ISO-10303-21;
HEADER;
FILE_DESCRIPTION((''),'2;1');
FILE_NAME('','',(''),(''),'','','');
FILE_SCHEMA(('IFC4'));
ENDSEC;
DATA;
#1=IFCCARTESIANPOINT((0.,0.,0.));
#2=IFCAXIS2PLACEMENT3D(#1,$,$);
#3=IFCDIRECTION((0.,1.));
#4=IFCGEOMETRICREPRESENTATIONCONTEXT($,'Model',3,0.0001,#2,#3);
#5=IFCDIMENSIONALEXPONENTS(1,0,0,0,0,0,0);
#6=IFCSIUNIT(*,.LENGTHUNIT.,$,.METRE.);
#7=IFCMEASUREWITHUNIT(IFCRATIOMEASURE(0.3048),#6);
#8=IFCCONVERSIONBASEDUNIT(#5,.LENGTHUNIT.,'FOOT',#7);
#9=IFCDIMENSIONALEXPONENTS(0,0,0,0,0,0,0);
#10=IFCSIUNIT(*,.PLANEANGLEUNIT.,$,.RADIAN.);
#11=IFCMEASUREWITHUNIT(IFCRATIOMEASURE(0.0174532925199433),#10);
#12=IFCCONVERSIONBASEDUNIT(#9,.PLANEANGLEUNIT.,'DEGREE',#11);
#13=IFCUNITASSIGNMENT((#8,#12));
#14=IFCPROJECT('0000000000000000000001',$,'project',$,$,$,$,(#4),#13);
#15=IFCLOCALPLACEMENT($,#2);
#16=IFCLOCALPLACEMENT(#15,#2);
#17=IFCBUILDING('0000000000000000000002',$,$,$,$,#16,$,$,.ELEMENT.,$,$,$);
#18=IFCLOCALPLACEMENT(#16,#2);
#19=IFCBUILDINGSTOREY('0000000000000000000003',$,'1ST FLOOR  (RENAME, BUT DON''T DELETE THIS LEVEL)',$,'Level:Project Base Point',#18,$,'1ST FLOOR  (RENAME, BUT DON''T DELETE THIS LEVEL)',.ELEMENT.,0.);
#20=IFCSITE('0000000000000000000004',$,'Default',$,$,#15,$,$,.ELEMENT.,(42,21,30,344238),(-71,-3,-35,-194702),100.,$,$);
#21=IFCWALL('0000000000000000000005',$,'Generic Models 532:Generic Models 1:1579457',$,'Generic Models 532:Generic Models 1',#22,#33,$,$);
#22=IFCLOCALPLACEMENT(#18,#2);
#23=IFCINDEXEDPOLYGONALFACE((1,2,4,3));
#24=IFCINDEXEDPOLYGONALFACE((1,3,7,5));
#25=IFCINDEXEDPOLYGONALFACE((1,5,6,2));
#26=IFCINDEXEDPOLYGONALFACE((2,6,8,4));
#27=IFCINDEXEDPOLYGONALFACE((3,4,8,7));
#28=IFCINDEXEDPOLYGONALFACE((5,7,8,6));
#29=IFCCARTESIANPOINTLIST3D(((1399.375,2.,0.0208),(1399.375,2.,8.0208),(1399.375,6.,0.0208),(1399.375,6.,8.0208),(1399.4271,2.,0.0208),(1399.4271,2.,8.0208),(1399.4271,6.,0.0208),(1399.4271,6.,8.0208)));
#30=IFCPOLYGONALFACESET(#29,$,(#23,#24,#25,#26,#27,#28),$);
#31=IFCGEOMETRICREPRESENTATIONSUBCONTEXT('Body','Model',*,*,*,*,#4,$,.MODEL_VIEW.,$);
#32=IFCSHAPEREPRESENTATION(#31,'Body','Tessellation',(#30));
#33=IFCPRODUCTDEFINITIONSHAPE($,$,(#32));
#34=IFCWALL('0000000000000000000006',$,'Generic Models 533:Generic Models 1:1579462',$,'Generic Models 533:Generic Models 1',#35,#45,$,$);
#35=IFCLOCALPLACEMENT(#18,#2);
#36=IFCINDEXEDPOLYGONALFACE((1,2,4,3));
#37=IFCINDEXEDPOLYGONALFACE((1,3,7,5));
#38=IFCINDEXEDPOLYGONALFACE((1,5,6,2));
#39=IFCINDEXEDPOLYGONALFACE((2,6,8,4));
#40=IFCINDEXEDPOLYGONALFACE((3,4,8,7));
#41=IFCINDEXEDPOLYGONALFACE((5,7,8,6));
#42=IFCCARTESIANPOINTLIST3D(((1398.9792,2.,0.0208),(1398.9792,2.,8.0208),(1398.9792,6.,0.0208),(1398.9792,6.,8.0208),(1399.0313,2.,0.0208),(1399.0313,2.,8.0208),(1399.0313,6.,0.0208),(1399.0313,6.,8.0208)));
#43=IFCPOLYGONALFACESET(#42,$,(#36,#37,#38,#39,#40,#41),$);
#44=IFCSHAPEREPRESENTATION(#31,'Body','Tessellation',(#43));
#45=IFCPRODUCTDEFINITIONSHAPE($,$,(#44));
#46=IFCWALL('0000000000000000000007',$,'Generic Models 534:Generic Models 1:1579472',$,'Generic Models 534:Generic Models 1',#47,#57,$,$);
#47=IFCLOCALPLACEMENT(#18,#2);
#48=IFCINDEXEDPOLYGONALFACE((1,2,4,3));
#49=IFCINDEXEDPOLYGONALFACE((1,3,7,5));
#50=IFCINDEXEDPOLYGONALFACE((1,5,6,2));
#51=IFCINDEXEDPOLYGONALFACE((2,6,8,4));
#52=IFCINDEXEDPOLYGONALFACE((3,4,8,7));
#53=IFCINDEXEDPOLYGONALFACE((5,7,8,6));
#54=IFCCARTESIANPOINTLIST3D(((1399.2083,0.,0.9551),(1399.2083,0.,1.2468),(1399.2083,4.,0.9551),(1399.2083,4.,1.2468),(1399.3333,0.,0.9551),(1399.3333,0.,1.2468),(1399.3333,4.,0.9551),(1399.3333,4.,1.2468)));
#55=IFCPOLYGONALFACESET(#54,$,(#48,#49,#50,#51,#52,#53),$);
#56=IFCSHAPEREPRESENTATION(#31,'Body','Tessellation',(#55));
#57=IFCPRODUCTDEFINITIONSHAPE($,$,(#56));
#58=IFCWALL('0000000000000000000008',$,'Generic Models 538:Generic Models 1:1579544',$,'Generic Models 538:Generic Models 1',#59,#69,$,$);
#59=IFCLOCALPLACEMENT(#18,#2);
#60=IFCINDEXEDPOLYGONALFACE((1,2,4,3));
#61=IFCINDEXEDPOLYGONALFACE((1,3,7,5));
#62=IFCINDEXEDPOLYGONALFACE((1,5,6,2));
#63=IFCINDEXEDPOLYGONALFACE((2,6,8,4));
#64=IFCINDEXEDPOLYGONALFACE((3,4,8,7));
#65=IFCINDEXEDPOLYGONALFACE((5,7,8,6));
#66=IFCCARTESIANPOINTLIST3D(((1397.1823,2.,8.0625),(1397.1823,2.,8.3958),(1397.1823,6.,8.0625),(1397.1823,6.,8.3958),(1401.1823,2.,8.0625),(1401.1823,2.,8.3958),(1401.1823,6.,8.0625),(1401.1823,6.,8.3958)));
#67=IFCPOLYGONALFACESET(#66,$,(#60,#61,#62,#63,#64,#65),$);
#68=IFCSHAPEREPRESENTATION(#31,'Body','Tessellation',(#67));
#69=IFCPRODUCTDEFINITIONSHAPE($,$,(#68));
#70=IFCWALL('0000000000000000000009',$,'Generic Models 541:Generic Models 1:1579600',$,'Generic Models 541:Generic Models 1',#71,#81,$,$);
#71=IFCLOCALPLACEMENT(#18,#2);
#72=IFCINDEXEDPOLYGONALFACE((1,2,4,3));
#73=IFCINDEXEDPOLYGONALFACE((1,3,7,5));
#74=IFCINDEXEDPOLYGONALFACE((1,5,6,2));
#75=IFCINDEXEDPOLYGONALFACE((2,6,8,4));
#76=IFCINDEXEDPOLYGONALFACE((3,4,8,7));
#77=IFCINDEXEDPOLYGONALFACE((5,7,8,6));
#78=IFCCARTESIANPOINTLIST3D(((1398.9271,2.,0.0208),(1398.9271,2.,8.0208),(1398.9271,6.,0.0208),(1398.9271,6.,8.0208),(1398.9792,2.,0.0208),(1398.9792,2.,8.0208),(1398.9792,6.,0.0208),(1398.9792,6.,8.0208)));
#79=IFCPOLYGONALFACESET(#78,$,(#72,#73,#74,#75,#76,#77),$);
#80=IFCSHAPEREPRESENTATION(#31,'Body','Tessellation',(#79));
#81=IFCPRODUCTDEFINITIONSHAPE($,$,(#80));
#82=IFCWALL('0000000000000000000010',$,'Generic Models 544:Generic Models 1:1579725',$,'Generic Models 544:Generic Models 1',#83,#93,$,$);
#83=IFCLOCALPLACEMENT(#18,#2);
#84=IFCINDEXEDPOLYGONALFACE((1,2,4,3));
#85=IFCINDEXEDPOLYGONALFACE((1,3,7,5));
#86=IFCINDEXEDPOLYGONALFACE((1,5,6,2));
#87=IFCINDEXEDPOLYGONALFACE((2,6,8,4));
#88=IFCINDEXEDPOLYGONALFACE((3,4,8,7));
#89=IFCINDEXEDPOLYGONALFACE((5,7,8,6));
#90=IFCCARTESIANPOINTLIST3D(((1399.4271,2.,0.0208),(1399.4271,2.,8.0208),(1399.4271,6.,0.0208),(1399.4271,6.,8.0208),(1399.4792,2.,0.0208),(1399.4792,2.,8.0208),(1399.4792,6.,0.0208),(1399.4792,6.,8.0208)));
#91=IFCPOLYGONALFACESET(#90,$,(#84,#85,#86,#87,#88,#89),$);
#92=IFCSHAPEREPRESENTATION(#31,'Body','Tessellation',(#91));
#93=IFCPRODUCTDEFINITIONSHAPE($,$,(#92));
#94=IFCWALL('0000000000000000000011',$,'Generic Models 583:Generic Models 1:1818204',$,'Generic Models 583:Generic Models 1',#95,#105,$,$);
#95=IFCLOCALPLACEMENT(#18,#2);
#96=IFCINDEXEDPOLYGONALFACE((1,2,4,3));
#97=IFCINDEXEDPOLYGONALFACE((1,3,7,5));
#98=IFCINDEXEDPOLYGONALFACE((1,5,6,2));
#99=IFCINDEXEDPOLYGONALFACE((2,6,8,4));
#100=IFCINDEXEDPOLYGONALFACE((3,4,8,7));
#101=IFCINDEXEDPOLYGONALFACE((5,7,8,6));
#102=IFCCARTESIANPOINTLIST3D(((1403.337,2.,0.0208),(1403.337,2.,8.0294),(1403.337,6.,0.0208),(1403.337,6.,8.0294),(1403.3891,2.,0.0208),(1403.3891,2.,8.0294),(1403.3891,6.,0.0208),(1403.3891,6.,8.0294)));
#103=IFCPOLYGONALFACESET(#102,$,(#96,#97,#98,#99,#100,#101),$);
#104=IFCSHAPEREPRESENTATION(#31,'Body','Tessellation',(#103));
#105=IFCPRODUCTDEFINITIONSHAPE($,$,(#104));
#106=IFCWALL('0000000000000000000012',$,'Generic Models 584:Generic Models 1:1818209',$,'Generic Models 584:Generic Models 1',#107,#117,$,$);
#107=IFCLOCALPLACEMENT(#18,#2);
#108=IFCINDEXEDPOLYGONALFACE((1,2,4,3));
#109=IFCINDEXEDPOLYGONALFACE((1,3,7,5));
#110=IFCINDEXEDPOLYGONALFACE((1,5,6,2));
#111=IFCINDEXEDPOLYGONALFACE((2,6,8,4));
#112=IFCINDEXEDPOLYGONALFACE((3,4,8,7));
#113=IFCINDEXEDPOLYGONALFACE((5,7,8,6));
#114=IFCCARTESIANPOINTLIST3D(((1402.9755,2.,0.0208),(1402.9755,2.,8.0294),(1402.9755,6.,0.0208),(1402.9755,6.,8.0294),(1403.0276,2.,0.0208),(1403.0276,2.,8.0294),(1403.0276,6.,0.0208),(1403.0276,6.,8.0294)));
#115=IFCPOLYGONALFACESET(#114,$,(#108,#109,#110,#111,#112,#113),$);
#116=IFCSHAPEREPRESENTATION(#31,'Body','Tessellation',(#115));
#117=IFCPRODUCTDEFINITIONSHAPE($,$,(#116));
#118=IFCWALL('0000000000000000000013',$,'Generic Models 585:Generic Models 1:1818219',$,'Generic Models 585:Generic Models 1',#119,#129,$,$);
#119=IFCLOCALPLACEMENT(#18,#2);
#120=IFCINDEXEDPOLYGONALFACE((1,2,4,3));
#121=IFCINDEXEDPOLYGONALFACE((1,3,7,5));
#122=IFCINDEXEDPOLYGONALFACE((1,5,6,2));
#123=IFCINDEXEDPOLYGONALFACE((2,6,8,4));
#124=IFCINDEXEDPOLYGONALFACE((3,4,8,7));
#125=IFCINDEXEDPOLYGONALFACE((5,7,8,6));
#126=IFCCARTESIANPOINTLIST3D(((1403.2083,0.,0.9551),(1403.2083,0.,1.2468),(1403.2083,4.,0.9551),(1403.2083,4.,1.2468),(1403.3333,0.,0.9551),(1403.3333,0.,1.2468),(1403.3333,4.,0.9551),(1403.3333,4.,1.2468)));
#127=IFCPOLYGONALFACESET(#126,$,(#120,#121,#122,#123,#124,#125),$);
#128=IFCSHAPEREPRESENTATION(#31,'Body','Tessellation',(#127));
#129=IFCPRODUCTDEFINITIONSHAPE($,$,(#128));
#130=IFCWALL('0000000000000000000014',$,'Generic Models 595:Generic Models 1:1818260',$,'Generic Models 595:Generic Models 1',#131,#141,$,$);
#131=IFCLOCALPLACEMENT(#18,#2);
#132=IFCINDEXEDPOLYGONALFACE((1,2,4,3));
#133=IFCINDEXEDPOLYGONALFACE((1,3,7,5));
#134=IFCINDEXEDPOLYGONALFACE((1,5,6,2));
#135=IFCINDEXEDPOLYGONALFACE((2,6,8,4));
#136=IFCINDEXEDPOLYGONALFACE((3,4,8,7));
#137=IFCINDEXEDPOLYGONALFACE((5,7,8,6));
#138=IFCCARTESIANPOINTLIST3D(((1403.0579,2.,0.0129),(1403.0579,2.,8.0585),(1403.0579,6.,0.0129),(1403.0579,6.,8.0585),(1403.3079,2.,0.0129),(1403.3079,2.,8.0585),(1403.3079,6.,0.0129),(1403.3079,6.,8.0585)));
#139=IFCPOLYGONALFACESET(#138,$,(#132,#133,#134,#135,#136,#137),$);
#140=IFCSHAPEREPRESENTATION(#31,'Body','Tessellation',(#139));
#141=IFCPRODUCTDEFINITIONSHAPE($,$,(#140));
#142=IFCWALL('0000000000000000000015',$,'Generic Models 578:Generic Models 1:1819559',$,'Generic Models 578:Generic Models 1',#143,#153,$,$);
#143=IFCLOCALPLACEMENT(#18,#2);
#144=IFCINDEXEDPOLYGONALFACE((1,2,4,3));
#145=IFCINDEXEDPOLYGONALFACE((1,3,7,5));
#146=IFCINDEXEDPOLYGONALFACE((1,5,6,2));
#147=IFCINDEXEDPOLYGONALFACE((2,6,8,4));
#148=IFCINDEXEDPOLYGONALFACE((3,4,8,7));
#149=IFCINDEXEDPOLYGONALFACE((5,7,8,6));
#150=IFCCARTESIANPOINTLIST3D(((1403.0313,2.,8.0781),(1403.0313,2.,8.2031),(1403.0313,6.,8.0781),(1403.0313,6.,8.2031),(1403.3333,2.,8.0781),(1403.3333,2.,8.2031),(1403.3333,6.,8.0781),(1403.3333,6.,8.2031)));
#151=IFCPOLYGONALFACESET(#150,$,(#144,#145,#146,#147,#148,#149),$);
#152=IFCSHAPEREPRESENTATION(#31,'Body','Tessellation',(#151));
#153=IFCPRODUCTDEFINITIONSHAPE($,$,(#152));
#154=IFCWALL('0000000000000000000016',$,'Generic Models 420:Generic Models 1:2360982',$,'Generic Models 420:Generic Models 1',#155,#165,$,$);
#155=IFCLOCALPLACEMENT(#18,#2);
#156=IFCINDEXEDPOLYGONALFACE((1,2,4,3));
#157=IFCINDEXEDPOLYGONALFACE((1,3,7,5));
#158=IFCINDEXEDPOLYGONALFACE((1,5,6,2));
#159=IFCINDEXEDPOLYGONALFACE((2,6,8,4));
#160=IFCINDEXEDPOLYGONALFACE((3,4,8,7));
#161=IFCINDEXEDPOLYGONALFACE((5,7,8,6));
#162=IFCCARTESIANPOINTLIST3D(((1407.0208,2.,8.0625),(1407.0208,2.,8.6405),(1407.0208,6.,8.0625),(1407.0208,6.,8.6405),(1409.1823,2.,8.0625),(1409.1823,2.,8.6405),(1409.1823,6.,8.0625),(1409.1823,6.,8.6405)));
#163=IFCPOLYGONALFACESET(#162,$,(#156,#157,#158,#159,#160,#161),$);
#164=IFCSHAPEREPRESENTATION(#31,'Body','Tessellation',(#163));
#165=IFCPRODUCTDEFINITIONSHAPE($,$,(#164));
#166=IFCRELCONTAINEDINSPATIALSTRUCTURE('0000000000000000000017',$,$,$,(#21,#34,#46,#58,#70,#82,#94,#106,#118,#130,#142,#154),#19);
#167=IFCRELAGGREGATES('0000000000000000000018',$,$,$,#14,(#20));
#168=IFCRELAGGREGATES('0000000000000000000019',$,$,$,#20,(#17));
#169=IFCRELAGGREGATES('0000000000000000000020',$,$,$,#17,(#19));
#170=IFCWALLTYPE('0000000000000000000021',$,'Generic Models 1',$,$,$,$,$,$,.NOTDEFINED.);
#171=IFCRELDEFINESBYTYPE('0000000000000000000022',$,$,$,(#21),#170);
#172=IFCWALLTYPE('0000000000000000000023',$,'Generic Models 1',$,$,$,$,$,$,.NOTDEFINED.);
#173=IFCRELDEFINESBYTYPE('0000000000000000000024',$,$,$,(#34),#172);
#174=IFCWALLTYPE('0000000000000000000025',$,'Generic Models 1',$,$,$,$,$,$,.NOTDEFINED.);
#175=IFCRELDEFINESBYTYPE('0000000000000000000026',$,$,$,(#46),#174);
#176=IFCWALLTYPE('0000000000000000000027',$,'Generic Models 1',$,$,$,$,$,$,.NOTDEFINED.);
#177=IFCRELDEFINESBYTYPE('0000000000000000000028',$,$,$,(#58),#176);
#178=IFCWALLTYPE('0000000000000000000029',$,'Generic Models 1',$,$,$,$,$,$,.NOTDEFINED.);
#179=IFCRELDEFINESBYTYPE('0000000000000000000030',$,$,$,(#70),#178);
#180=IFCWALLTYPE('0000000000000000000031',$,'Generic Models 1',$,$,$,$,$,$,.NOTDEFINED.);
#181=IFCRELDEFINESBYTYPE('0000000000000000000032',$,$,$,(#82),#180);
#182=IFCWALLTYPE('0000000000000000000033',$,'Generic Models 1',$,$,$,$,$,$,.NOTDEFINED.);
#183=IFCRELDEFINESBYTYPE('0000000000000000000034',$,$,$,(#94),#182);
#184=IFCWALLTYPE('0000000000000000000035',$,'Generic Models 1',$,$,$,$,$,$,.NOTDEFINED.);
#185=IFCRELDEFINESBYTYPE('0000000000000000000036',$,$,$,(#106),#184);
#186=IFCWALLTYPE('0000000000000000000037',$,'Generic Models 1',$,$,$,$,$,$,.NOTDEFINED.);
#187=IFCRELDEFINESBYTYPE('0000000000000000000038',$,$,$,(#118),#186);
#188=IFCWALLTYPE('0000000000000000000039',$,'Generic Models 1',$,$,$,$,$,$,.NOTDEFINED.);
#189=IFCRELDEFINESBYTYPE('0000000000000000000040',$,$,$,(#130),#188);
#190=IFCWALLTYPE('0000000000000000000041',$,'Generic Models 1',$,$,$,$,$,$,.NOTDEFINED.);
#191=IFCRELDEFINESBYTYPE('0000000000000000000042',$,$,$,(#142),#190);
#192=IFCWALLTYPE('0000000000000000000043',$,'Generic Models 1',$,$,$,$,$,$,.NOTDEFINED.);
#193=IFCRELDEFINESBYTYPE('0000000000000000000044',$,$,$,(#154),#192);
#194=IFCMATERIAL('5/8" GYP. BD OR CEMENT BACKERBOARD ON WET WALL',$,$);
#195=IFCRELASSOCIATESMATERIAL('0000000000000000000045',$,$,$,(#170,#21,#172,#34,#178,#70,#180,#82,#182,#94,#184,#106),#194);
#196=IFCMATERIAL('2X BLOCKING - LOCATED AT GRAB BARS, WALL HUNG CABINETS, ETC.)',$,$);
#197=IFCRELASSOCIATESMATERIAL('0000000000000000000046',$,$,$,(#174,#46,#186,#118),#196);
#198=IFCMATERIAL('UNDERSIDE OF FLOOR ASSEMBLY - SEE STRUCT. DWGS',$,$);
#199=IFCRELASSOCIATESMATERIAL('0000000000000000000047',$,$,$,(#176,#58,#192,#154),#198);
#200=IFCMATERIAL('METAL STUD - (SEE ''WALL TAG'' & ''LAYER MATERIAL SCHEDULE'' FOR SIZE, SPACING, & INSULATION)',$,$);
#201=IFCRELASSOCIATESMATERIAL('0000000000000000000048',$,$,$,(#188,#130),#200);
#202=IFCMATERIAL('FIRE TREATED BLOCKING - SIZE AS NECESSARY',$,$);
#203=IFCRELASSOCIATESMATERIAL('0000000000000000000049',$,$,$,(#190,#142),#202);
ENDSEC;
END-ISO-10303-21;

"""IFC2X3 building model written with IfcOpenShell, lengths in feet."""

from ifc_helpers import new_model, entity, si_unit, converted_unit, direction, frame, frame_2d, origin, origin_2d_with_axis, place, context, subcontext, project, spatial, rectangle, extrude, material, type_object, element, save


model = new_model("IFC2X3")

# Units and contexts
model_context = context("Model", 3, precision=0.0001, world=origin(), true_north=direction((0.0, 1.0)))
body_context = subcontext(model_context, "Body", "Model", "MODEL_VIEW")
ifc_project = project(units=[converted_unit("LENGTHUNIT", "FOOT", entity("IfcRatioMeasure", 0.3048), si_unit("LENGTHUNIT", "METRE"), dimensions=[1, 0, 0, 0, 0, 0, 0]), converted_unit("PLANEANGLEUNIT", "DEGREE", entity("IfcRatioMeasure", 0.0174532925199433), si_unit("PLANEANGLEUNIT", "RADIAN"), dimensions=[0, 0, 0, 0, 0, 0, 0])], contexts=[model_context])

# Site, building, storey
site_placement = place(None, origin())
site = spatial("IfcSite", under=ifc_project, at=site_placement, Name="Default", CompositionType="ELEMENT", RefLatitude=(42, 21, 30, 344238), RefLongitude=(-71, -3, -35, -194702), RefElevation=100.0)
building_placement = place(site_placement, origin())
building = spatial("IfcBuilding", under=site, at=building_placement, CompositionType="ELEMENT")
storey_placement = place(building_placement, origin())
storey = spatial("IfcBuildingStorey", under=building, at=storey_placement, Name="1ST FLOOR  (RENAME, BUT DON'T DELETE THIS LEVEL)", ObjectType="Level:Project Base Point", LongName="1ST FLOOR  (RENAME, BUT DON'T DELETE THIS LEVEL)", CompositionType="ELEMENT", Elevation=0.0)

# Walls
ifc_material_1 = material(Name="METAL STUD - (SEE 'WALL TAG' & 'LAYER MATERIAL SCHEDULE' FOR SIZE, SPACING, & INSULATION)")
ifc_material_2 = material(Name="5/8\" GYP. BD OR CEMENT BACKERBOARD ON WET WALL")
ifc_material_3 = material(Name="2X BLOCKING - LOCATED AT GRAB BARS, WALL HUNG CABINETS, ETC.)")
ifc_material_4 = material(Name="UNDERSIDE OF FLOOR ASSEMBLY - SEE STRUCT. DWGS")
wall_type_1 = type_object("IfcWallType", Name="Generic Models 1", PredefinedType="NOTDEFINED", material=ifc_material_2)
wall_1_placement = place(storey_placement, frame((1399.375, 2.0, 0.0208), z_axis=(0.0, 0.0, 1.0), x_axis=(0.0, 1.0, 0.0)))
element("IfcWall", 1, at=wall_1_placement, inside=storey, type_object=wall_type_1, material=ifc_material_2, Name="Generic Models 532:Generic Models 1:1579457", ObjectType="Generic Models 532:Generic Models 1", context=body_context, shape_type="SweptSolid", body=[
    extrude(rectangle(XDim=4.0, YDim=0.0521, at=frame_2d((0.0, 0.0), x_axis=(1.0, 0.0))), frame((2.0, -0.026, 0.0)), (0.0, 0.0, 1.0), 8.0),
])
wall_type_2 = type_object("IfcWallType", Name="Generic Models 1", PredefinedType="NOTDEFINED", material=ifc_material_2)
wall_2_placement = place(storey_placement, frame((1398.9792, 2.0, 0.0208), z_axis=(0.0, 0.0, 1.0), x_axis=(0.0, 1.0, 0.0)))
element("IfcWall", 2, at=wall_2_placement, inside=storey, type_object=wall_type_2, material=ifc_material_2, Name="Generic Models 533:Generic Models 1:1579462", ObjectType="Generic Models 533:Generic Models 1", context=body_context, shape_type="SweptSolid", body=[
    extrude(rectangle(XDim=4.0, YDim=0.0521, at=frame_2d((0.0, 0.0), x_axis=(1.0, 0.0))), frame((2.0, -0.026, 0.0)), (0.0, 0.0, 1.0), 8.0),
])
wall_type_3 = type_object("IfcWallType", Name="Generic Models 1", PredefinedType="NOTDEFINED", material=ifc_material_3)
wall_3_placement = place(storey_placement, frame((1399.2083, 0.0, 0.9551), z_axis=(0.0, 0.0, 1.0), x_axis=(0.0, 1.0, 0.0)))
element("IfcWall", 3, at=wall_3_placement, inside=storey, type_object=wall_type_3, material=ifc_material_3, Name="Generic Models 534:Generic Models 1:1579472", ObjectType="Generic Models 534:Generic Models 1", context=body_context, shape_type="SweptSolid", body=[
    extrude(rectangle(XDim=4.0, YDim=0.125, at=frame_2d((0.0, 0.0), x_axis=(1.0, 0.0))), frame((2.0, -0.0625, 0.0)), (0.0, 0.0, 1.0), 0.2917),
])
wall_type_4 = type_object("IfcWallType", Name="Generic Models 1", PredefinedType="NOTDEFINED", material=ifc_material_4)
wall_4_placement = place(storey_placement, frame((1397.1823, 2.0, 8.0625), z_axis=(0.0, 0.0, 1.0), x_axis=(0.0, 1.0, 0.0)))
element("IfcWall", 4, at=wall_4_placement, inside=storey, type_object=wall_type_4, material=ifc_material_4, Name="Generic Models 538:Generic Models 1:1579544", ObjectType="Generic Models 538:Generic Models 1", context=body_context, shape_type="SweptSolid", body=[
    extrude(rectangle(XDim=4.0, YDim=4.0, at=origin_2d_with_axis()), frame((2.0, -2.0, 0.0)), (0.0, 0.0, 1.0), 0.3333),
])
wall_type_5 = type_object("IfcWallType", Name="Generic Models 1", PredefinedType="NOTDEFINED", material=ifc_material_2)
wall_5_placement = place(storey_placement, frame((1398.9271, 2.0, 0.0208), z_axis=(0.0, 0.0, 1.0), x_axis=(0.0, 1.0, 0.0)))
element("IfcWall", 5, at=wall_5_placement, inside=storey, type_object=wall_type_5, material=ifc_material_2, Name="Generic Models 541:Generic Models 1:1579600", ObjectType="Generic Models 541:Generic Models 1", context=body_context, shape_type="SweptSolid", body=[
    extrude(rectangle(XDim=4.0, YDim=0.0521, at=frame_2d((0.0, 0.0), x_axis=(1.0, 0.0))), frame((2.0, -0.026, 0.0)), (0.0, 0.0, 1.0), 8.0),
])
wall_type_6 = type_object("IfcWallType", Name="Generic Models 1", PredefinedType="NOTDEFINED", material=ifc_material_2)
wall_6_placement = place(storey_placement, frame((1399.4271, 2.0, 0.0208), z_axis=(0.0, 0.0, 1.0), x_axis=(0.0, 1.0, 0.0)))
element("IfcWall", 6, at=wall_6_placement, inside=storey, type_object=wall_type_6, material=ifc_material_2, Name="Generic Models 544:Generic Models 1:1579725", ObjectType="Generic Models 544:Generic Models 1", context=body_context, shape_type="SweptSolid", body=[
    extrude(rectangle(XDim=4.0, YDim=0.0521, at=frame_2d((0.0, 0.0), x_axis=(1.0, 0.0))), frame((2.0, -0.026, 0.0)), (0.0, 0.0, 1.0), 8.0),
])
wall_type_7 = type_object("IfcWallType", Name="Generic Models 1", PredefinedType="NOTDEFINED", material=ifc_material_2)
wall_7_placement = place(storey_placement, frame((1403.337, 2.0, 0.0208), z_axis=(0.0, 0.0, 1.0), x_axis=(0.0, 1.0, 0.0)))
element("IfcWall", 7, at=wall_7_placement, inside=storey, type_object=wall_type_7, material=ifc_material_2, Name="Generic Models 583:Generic Models 1:1818204", ObjectType="Generic Models 583:Generic Models 1", context=body_context, shape_type="SweptSolid", body=[
    extrude(rectangle(XDim=4.0, YDim=0.0521, at=frame_2d((0.0, 0.0), x_axis=(1.0, 0.0))), frame((2.0, -0.026, 0.0)), (0.0, 0.0, 1.0), 8.0086),
])
wall_type_8 = type_object("IfcWallType", Name="Generic Models 1", PredefinedType="NOTDEFINED", material=ifc_material_2)
wall_8_placement = place(storey_placement, frame((1402.9755, 2.0, 0.0208), z_axis=(0.0, 0.0, 1.0), x_axis=(0.0, 1.0, 0.0)))
element("IfcWall", 8, at=wall_8_placement, inside=storey, type_object=wall_type_8, material=ifc_material_2, Name="Generic Models 584:Generic Models 1:1818209", ObjectType="Generic Models 584:Generic Models 1", context=body_context, shape_type="SweptSolid", body=[
    extrude(rectangle(XDim=4.0, YDim=0.0521, at=frame_2d((0.0, 0.0), x_axis=(1.0, 0.0))), frame((2.0, -0.026, 0.0)), (0.0, 0.0, 1.0), 8.0086),
])
wall_type_9 = type_object("IfcWallType", Name="Generic Models 1", PredefinedType="NOTDEFINED", material=ifc_material_3)
wall_9_placement = place(storey_placement, frame((1403.2083, 0.0, 0.9551), z_axis=(0.0, 0.0, 1.0), x_axis=(0.0, 1.0, 0.0)))
element("IfcWall", 9, at=wall_9_placement, inside=storey, type_object=wall_type_9, material=ifc_material_3, Name="Generic Models 585:Generic Models 1:1818219", ObjectType="Generic Models 585:Generic Models 1", context=body_context, shape_type="SweptSolid", body=[
    extrude(rectangle(XDim=4.0, YDim=0.125, at=frame_2d((0.0, 0.0), x_axis=(1.0, 0.0))), frame((2.0, -0.0625, 0.0)), (0.0, 0.0, 1.0), 0.2917),
])
wall_type_10 = type_object("IfcWallType", Name="Generic Models 1", PredefinedType="NOTDEFINED", material=ifc_material_1)
wall_10_placement = place(storey_placement, frame((1403.0579, 2.0, 0.0129), z_axis=(0.0, 0.0, 1.0), x_axis=(0.0, 1.0, 0.0)))
element("IfcWall", 10, at=wall_10_placement, inside=storey, type_object=wall_type_10, material=ifc_material_1, Name="Generic Models 595:Generic Models 1:1818260", ObjectType="Generic Models 595:Generic Models 1", context=body_context, shape_type="SweptSolid", body=[
    extrude(rectangle(XDim=4.0, YDim=0.25, at=frame_2d((0.0, 0.0), x_axis=(1.0, 0.0))), frame((2.0, -0.125, 0.0)), (0.0, 0.0, 1.0), 8.0457),
])
ifc_material_5 = material(Name="FIRE TREATED BLOCKING - SIZE AS NECESSARY")
wall_type_11 = type_object("IfcWallType", Name="Generic Models 1", PredefinedType="NOTDEFINED", material=ifc_material_5)
wall_11_placement = place(storey_placement, frame((1403.0312, 2.0, 8.0781), z_axis=(0.0, 0.0, 1.0), x_axis=(0.0, 1.0, 0.0)))
element("IfcWall", 11, at=wall_11_placement, inside=storey, type_object=wall_type_11, material=ifc_material_5, Name="Generic Models 578:Generic Models 1:1819559", ObjectType="Generic Models 578:Generic Models 1", context=body_context, shape_type="SweptSolid", body=[
    extrude(rectangle(XDim=4.0, YDim=0.3021, at=frame_2d((0.0, 0.0), x_axis=(1.0, 0.0))), frame((2.0, -0.151, 0.0)), (0.0, 0.0, 1.0), 0.125),
])
wall_type_12 = type_object("IfcWallType", Name="Generic Models 1", PredefinedType="NOTDEFINED", material=ifc_material_4)
wall_12_placement = place(storey_placement, frame((1407.0208, 2.0, 8.0625), z_axis=(0.0, 0.0, 1.0), x_axis=(0.0, 1.0, 0.0)))
element("IfcWall", 12, at=wall_12_placement, inside=storey, type_object=wall_type_12, material=ifc_material_4, Name="Generic Models 420:Generic Models 1:2360982", ObjectType="Generic Models 420:Generic Models 1", context=body_context, shape_type="SweptSolid", body=[
    extrude(rectangle(XDim=4.0, YDim=2.1615, at=frame_2d((0.0, 0.0), x_axis=(1.0, 0.0))), frame((2.0, -1.0807, 0.0)), (0.0, 0.0, 1.0), 0.578),
])

save(model, "model.ifc")
